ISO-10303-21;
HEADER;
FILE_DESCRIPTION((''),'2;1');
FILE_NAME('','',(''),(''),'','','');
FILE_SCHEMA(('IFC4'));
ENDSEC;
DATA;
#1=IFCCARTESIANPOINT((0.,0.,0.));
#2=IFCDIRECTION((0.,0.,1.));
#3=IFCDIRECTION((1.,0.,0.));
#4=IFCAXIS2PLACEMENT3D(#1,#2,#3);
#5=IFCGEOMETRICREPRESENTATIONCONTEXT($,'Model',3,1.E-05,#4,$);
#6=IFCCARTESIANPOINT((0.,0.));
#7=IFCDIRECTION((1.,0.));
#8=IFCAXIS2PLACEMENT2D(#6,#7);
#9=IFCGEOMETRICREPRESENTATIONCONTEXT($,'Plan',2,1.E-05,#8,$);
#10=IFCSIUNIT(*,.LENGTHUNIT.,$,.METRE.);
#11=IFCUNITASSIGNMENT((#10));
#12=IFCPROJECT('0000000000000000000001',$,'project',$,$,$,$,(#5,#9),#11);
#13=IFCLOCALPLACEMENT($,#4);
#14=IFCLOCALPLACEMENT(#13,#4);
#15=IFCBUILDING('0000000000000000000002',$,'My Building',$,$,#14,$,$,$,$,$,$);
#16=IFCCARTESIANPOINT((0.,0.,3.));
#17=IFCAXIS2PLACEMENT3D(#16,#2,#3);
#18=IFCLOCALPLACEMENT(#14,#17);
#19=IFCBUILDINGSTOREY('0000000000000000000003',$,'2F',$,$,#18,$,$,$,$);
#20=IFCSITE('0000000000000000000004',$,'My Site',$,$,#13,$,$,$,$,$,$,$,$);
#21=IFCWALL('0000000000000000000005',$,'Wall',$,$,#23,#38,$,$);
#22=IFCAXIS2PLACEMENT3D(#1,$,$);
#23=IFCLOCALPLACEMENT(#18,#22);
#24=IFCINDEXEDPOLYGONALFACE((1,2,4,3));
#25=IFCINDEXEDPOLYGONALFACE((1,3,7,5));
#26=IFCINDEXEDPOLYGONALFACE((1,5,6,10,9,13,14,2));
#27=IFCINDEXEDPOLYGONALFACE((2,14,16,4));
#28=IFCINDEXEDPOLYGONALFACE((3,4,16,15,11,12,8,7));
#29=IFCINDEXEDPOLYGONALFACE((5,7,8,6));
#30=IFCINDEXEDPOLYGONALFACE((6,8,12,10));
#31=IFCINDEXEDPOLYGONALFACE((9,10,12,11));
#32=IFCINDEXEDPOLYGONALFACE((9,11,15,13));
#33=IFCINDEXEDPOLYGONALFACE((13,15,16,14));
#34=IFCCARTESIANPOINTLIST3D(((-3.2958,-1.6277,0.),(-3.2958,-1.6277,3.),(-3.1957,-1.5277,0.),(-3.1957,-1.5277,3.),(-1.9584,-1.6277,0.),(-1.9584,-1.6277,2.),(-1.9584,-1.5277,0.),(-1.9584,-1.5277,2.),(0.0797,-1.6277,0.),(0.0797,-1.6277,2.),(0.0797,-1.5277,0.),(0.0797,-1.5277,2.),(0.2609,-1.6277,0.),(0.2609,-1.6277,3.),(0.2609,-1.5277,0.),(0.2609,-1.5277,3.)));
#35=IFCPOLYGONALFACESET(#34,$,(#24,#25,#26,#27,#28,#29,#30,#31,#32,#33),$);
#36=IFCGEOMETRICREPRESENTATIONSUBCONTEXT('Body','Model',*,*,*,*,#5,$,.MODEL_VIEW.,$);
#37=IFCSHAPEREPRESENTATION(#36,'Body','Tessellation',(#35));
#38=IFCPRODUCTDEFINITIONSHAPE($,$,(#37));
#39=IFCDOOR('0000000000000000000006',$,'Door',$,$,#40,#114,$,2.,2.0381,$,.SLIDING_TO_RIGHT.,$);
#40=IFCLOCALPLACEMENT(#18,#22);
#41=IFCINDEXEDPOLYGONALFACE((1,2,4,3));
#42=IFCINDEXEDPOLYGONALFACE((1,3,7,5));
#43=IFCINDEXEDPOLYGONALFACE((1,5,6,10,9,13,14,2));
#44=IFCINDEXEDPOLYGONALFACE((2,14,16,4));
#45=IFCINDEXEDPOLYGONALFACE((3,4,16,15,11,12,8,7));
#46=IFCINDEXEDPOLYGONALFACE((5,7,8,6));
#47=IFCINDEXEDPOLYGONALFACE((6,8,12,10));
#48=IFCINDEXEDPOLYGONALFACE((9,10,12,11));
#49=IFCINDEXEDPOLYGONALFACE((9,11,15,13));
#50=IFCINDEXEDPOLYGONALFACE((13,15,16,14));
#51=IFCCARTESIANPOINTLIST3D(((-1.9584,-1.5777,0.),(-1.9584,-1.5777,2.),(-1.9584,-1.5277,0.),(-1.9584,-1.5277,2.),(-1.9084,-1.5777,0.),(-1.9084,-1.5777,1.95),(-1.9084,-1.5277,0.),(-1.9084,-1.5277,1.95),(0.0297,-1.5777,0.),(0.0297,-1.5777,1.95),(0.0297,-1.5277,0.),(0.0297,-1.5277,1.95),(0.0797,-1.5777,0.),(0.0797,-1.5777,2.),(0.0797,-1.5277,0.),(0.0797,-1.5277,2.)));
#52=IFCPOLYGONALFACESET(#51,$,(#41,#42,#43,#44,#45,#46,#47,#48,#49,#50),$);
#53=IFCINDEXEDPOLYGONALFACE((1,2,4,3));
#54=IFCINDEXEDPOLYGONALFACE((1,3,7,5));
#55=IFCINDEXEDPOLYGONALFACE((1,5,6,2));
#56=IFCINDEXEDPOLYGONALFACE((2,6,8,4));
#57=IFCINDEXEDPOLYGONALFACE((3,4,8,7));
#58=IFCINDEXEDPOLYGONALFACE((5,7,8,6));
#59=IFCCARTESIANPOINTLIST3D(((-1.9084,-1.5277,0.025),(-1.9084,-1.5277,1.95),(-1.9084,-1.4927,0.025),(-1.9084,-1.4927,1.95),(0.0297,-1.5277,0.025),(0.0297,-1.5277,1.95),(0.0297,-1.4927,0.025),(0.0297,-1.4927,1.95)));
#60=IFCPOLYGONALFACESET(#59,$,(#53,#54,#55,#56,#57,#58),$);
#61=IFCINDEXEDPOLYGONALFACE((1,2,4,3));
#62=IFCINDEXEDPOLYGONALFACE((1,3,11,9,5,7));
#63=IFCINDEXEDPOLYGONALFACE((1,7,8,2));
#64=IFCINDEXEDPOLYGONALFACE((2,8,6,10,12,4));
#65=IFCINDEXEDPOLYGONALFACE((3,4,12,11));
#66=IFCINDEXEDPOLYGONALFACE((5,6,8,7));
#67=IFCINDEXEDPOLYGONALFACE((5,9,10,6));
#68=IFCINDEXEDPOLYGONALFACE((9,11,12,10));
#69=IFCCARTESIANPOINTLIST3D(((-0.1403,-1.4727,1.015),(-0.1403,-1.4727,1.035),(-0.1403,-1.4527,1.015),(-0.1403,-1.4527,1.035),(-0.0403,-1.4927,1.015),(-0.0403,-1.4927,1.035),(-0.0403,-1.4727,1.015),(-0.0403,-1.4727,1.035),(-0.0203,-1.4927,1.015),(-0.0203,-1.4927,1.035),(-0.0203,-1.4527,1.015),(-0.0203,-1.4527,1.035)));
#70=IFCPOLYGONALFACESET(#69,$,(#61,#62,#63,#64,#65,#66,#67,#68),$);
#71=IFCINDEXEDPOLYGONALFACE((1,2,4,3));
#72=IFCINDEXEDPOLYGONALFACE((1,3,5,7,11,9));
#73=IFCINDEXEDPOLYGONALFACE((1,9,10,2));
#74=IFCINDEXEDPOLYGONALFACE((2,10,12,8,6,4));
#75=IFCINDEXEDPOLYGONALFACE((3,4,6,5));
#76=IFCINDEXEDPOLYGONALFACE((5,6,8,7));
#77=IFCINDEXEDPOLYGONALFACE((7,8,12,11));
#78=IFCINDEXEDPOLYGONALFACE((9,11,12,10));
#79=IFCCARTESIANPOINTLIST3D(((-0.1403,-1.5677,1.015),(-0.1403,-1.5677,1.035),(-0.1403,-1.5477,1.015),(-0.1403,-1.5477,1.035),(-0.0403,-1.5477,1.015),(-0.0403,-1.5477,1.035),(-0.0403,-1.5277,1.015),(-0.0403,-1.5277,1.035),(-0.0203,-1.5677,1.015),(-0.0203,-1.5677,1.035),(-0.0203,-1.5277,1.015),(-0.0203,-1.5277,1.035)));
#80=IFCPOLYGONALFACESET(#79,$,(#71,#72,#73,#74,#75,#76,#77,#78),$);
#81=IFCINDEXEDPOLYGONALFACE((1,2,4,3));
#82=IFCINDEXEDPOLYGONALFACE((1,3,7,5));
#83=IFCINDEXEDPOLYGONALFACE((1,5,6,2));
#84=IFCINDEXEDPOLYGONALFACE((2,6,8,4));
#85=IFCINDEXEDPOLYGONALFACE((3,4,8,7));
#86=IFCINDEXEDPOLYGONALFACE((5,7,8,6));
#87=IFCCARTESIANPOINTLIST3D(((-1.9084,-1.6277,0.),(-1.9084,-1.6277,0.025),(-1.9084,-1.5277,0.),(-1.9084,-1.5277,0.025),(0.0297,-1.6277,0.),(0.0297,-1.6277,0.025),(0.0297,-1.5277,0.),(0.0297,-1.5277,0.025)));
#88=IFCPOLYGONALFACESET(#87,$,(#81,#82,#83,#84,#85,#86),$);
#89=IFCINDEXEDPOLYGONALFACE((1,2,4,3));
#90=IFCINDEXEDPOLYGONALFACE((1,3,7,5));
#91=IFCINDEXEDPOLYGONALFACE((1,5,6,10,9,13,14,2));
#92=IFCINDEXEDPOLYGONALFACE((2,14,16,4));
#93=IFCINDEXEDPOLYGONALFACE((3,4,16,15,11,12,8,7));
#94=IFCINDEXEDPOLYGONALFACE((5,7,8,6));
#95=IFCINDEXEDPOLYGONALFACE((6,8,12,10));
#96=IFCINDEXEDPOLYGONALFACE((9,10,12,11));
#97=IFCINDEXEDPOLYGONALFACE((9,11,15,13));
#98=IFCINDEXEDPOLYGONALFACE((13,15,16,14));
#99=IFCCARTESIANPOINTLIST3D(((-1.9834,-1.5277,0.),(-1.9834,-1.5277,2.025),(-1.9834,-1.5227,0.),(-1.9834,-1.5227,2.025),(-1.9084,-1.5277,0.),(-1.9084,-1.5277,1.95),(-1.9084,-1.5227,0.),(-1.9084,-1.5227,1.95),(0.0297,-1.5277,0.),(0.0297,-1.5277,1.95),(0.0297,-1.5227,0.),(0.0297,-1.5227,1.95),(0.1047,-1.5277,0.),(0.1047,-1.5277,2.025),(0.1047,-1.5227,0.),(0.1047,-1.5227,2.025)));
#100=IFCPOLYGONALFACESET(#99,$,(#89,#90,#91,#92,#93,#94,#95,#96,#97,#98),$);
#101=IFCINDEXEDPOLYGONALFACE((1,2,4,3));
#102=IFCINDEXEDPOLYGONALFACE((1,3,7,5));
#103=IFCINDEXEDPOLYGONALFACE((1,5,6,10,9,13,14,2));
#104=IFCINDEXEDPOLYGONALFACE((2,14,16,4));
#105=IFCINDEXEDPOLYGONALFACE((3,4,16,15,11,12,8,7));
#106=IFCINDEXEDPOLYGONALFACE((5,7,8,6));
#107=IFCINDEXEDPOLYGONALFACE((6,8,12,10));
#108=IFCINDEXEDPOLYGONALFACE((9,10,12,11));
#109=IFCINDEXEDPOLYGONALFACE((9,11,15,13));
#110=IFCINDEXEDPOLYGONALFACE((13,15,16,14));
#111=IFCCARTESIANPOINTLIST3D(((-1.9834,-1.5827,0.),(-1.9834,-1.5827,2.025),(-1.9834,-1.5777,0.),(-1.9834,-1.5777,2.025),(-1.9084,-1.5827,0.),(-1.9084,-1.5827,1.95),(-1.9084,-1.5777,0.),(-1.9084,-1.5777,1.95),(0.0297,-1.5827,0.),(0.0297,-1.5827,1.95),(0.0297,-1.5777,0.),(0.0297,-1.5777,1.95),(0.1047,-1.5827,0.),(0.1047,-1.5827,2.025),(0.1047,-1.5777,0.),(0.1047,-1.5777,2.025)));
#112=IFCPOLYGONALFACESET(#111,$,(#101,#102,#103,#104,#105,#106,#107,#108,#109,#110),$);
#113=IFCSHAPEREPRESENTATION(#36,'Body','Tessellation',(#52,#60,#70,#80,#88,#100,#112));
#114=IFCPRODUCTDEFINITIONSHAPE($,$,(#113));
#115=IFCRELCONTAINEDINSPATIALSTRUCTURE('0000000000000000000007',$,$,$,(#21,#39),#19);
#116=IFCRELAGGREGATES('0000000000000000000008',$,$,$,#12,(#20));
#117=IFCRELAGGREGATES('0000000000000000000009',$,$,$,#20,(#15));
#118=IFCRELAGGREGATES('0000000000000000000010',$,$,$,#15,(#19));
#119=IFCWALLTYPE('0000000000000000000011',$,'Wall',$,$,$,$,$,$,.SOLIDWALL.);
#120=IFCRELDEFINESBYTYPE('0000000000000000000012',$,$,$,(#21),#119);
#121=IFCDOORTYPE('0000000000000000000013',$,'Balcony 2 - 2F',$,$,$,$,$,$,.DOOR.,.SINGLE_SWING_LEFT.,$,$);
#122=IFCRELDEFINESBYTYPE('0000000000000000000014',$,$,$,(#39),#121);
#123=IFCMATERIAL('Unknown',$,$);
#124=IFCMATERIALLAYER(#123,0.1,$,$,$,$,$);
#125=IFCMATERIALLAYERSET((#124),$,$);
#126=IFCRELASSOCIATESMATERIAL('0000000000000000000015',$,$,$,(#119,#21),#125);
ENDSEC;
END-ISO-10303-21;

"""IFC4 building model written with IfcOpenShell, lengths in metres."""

from ifc_helpers import new_model, entity, si_unit, frame, origin_with_axes, origin_2d_with_axis, place, context, subcontext, project, spatial, line, indexed_curve, outline, extrude, shape, source, transform, mapped, material, layer, layer_set, layer_usage, type_object, type_shapes, element, fill, save


model = new_model("IFC4")

# Units and contexts
model_context = context("Model", 3, precision=1e-05, world=origin_with_axes())
plan_context = context("Plan", 2, precision=1e-05, world=origin_2d_with_axis())
body_context_1 = subcontext(model_context, "Body", "Model", "MODEL_VIEW")
body_context_2 = subcontext(plan_context, "Body", "Plan", "PLAN_VIEW")
ifc_project = project(units=[si_unit("LENGTHUNIT", "METRE")], contexts=[model_context, plan_context])

# Site, building, storey
site_placement = place(None, origin_with_axes())
site = spatial("IfcSite", under=ifc_project, at=site_placement, Name="My Site")
building_placement = place(site_placement, origin_with_axes())
building = spatial("IfcBuilding", under=site, at=building_placement, Name="My Building")
storey_placement = place(building_placement, frame((0.0, 0.0, 3.0), z_axis=(0.0, 0.0, 1.0), x_axis=(1.0, 0.0, 0.0)))
storey = spatial("IfcBuildingStorey", under=building, at=storey_placement, Name="2F")

# Shared definitions
ifc_material = material(Name="Unknown")

# Shared definitions
ifc_layer = layer(ifc_material, 0.1)
ifc_layer_set = layer_set([ifc_layer])
wall_type = type_object("IfcWallType", Name="Wall", PredefinedType="SOLIDWALL", material=ifc_layer_set)

# Wall, opening, door
ifc_layer_usage_1 = layer_usage(ifc_layer_set, "AXIS2", "POSITIVE", 0.0)
wall_1_placement = place(storey_placement, frame((-3.2958, -1.6277, 0.0), z_axis=(0.0, 0.0, 1.0), x_axis=(1.0, 0.0, 0.0)))
wall_1 = element("IfcWall", 1, at=wall_1_placement, inside=storey, type_object=wall_type, material=ifc_layer_usage_1, Name="Wall", context=body_context_1, shape_type="SweptSolid", body=[
    extrude(outline(indexed_curve([(0.0, 0.0), (0.1002, 0.1), (3.5568, 0.1), (3.5568, 0.0)], segments=[line(1, 2, 3, 4, 1)])), origin_with_axes(), (0.0, 0.0, 1.0), 3.0),
])
shared_shape_1 = source(origin_with_axes(), body_context_1, "Body", "SweptSolid", [
    extrude(outline(indexed_curve([(0.0, 0.0), (2.0381, 0.0), (2.0381, 2.0), (0.0, 2.0)], segments=[line(1, 2, 3, 4, 1)])), frame((0.0, -0.6, 0.0), z_axis=(0.0, -1.0, 0.0), x_axis=(1.0, 0.0, 0.0)), (0.0, 0.0, -1.0), 1.2),
])
opening_1_placement = place(wall_1_placement, frame((3.3755, 0.1, 0.0), z_axis=(0.0, 0.0, 1.0), x_axis=(-1.0, 0.0, 0.0)))
opening_1 = element("IfcOpeningElement", 2, at=opening_1_placement, cuts=wall_1, PredefinedType="OPENING", context=body_context_1, shape_type="MappedRepresentation", body=[
    mapped(shared_shape_1, transform((0.0, 0.0, 0.0), x_axis=(1.0, 0.0, 0.0), y_axis=(0.0, 1.0, 0.0), z_axis=(0.0, 0.0, 1.0), scale=1.0)),
])
door_type_1 = type_object("IfcDoorType", Name="Balcony 2 - 2F", OperationType="SINGLE_SWING_LEFT", PredefinedType="DOOR")
shared_shape_2 = source(origin_with_axes(), body_context_1, "Body", "SweptSolid", [
    extrude(outline(indexed_curve([(0.0, 0.0), (0.0, 2.0), (2.0381, 2.0), (2.0381, 0.0), (1.9881, 0.0), (1.9881, 1.95), (0.05, 1.95), (0.05, 0.0)], segments=[line(1, 2, 3, 4, 5, 6, 7, 8, 1)])), frame((0.0, 0.0, 0.0), z_axis=(0.0, -1.0, 0.0), x_axis=(1.0, 0.0, 0.0)), (0.0, 0.0, -1.0), 0.05),
    extrude(outline(indexed_curve([(0.0, 0.0), (1.9381, 0.0), (1.9381, 0.035), (0.0, 0.035)], segments=[line(1, 2, 3, 4, 1)])), frame((0.05, -0.035, 0.025), z_axis=(0.0, 0.0, 1.0), x_axis=(1.0, 0.0, 0.0)), (0.0, 0.0, 1.0), 1.925),
    extrude(outline(indexed_curve([(0.0, 0.0), (0.0, -0.04), (0.12, -0.04), (0.12, -0.02), (0.02, -0.02), (0.02, 0.0)], segments=[line(1, 2, 3, 4, 5, 6, 1)])), frame((0.1, -0.035, 1.015), z_axis=(0.0, 0.0, 1.0), x_axis=(1.0, 0.0, 0.0)), (0.0, 0.0, 1.0), 0.02),
    extrude(outline(indexed_curve([(0.0, 0.0), (0.0, 0.04), (0.12, 0.04), (0.12, 0.02), (0.02, 0.02), (0.02, 0.0)], segments=[line(1, 2, 3, 4, 5, 6, 1)])), frame((0.1, 0.0, 1.015), z_axis=(0.0, 0.0, 1.0), x_axis=(1.0, 0.0, 0.0)), (0.0, 0.0, 1.0), 0.02),
    extrude(outline(indexed_curve([(0.0, 0.0), (1.9381, 0.0), (1.9381, 0.1), (0.0, 0.1)], segments=[line(1, 2, 3, 4, 1)])), frame((0.05, 0.0, 0.0), z_axis=(0.0, 0.0, 1.0), x_axis=(1.0, 0.0, 0.0)), (0.0, 0.0, 1.0), 0.025),
    extrude(outline(indexed_curve([(0.0, 0.0), (0.0, 2.025), (2.0881, 2.025), (2.0881, 0.0), (2.0131, 0.0), (2.0131, 1.95), (0.075, 1.95), (0.075, 0.0)], segments=[line(1, 2, 3, 4, 5, 6, 7, 8, 1)])), frame((-0.025, -0.005, 0.0), z_axis=(0.0, -1.0, 0.0), x_axis=(1.0, 0.0, 0.0)), (0.0, 0.0, -1.0), 0.005),
    extrude(outline(indexed_curve([(0.0, 0.0), (0.0, 2.025), (2.0881, 2.025), (2.0881, 0.0), (2.0131, 0.0), (2.0131, 1.95), (0.075, 1.95), (0.075, 0.0)], segments=[line(1, 2, 3, 4, 5, 6, 7, 8, 1)])), frame((-0.025, 0.05, 0.0), z_axis=(0.0, -1.0, 0.0), x_axis=(1.0, 0.0, 0.0)), (0.0, 0.0, -1.0), 0.005),
])
shared_shape_3 = source(origin_with_axes(), body_context_2, "Body", "Curve2D", [
    entity("IfcIndexedPolyCurve", entity("IfcCartesianPointList2D", [[0.0, 0.0], [0.05, 0.0], [0.05, 0.05], [0.0, 0.05]]), [entity("IfcLineIndex", [1, 2, 3, 4, 1])]),
    entity("IfcIndexedPolyCurve", entity("IfcCartesianPointList2D", [[2.0381, 0.0], [1.9881, 0.0], [1.9881, 0.05], [2.0381, 0.05]]), [entity("IfcLineIndex", [1, 2, 3, 4, 1])]),
    entity("IfcIndexedPolyCurve", entity("IfcCartesianPointList2D", [[2.9571, -0.035], [1.019, -0.035], [1.019, 0.0], [2.9571, 0.0]]), [entity("IfcLineIndex", [1, 2, 3, 4, 1])]),
])
type_shapes(door_type_1, [shared_shape_2, shared_shape_3])
door_1_placement = place(opening_1_placement, origin_with_axes())
door_1 = element("IfcDoor", 3, at=door_1_placement, inside=storey, type_object=door_type_1, Name="Door", OperationType="SLIDING_TO_RIGHT", OverallHeight=2.0, OverallWidth=2.0381, shapes=[
    shape(body_context_1, "Body", "MappedRepresentation", [mapped(shared_shape_2, transform((0.0, 0.0, 0.0), x_axis=(1.0, 0.0, 0.0), y_axis=(0.0, 1.0, 0.0), z_axis=(0.0, 0.0, 1.0), scale=1.0))]),
    shape(body_context_2, "Body", "MappedRepresentation", [mapped(shared_shape_3, transform((0.0, 0.0, 0.0), x_axis=(1.0, 0.0, 0.0), y_axis=(0.0, 1.0, 0.0), z_axis=(0.0, 0.0, 1.0), scale=1.0))]),
])
fill(opening_1, door_1)

save(model, "model.ifc")
